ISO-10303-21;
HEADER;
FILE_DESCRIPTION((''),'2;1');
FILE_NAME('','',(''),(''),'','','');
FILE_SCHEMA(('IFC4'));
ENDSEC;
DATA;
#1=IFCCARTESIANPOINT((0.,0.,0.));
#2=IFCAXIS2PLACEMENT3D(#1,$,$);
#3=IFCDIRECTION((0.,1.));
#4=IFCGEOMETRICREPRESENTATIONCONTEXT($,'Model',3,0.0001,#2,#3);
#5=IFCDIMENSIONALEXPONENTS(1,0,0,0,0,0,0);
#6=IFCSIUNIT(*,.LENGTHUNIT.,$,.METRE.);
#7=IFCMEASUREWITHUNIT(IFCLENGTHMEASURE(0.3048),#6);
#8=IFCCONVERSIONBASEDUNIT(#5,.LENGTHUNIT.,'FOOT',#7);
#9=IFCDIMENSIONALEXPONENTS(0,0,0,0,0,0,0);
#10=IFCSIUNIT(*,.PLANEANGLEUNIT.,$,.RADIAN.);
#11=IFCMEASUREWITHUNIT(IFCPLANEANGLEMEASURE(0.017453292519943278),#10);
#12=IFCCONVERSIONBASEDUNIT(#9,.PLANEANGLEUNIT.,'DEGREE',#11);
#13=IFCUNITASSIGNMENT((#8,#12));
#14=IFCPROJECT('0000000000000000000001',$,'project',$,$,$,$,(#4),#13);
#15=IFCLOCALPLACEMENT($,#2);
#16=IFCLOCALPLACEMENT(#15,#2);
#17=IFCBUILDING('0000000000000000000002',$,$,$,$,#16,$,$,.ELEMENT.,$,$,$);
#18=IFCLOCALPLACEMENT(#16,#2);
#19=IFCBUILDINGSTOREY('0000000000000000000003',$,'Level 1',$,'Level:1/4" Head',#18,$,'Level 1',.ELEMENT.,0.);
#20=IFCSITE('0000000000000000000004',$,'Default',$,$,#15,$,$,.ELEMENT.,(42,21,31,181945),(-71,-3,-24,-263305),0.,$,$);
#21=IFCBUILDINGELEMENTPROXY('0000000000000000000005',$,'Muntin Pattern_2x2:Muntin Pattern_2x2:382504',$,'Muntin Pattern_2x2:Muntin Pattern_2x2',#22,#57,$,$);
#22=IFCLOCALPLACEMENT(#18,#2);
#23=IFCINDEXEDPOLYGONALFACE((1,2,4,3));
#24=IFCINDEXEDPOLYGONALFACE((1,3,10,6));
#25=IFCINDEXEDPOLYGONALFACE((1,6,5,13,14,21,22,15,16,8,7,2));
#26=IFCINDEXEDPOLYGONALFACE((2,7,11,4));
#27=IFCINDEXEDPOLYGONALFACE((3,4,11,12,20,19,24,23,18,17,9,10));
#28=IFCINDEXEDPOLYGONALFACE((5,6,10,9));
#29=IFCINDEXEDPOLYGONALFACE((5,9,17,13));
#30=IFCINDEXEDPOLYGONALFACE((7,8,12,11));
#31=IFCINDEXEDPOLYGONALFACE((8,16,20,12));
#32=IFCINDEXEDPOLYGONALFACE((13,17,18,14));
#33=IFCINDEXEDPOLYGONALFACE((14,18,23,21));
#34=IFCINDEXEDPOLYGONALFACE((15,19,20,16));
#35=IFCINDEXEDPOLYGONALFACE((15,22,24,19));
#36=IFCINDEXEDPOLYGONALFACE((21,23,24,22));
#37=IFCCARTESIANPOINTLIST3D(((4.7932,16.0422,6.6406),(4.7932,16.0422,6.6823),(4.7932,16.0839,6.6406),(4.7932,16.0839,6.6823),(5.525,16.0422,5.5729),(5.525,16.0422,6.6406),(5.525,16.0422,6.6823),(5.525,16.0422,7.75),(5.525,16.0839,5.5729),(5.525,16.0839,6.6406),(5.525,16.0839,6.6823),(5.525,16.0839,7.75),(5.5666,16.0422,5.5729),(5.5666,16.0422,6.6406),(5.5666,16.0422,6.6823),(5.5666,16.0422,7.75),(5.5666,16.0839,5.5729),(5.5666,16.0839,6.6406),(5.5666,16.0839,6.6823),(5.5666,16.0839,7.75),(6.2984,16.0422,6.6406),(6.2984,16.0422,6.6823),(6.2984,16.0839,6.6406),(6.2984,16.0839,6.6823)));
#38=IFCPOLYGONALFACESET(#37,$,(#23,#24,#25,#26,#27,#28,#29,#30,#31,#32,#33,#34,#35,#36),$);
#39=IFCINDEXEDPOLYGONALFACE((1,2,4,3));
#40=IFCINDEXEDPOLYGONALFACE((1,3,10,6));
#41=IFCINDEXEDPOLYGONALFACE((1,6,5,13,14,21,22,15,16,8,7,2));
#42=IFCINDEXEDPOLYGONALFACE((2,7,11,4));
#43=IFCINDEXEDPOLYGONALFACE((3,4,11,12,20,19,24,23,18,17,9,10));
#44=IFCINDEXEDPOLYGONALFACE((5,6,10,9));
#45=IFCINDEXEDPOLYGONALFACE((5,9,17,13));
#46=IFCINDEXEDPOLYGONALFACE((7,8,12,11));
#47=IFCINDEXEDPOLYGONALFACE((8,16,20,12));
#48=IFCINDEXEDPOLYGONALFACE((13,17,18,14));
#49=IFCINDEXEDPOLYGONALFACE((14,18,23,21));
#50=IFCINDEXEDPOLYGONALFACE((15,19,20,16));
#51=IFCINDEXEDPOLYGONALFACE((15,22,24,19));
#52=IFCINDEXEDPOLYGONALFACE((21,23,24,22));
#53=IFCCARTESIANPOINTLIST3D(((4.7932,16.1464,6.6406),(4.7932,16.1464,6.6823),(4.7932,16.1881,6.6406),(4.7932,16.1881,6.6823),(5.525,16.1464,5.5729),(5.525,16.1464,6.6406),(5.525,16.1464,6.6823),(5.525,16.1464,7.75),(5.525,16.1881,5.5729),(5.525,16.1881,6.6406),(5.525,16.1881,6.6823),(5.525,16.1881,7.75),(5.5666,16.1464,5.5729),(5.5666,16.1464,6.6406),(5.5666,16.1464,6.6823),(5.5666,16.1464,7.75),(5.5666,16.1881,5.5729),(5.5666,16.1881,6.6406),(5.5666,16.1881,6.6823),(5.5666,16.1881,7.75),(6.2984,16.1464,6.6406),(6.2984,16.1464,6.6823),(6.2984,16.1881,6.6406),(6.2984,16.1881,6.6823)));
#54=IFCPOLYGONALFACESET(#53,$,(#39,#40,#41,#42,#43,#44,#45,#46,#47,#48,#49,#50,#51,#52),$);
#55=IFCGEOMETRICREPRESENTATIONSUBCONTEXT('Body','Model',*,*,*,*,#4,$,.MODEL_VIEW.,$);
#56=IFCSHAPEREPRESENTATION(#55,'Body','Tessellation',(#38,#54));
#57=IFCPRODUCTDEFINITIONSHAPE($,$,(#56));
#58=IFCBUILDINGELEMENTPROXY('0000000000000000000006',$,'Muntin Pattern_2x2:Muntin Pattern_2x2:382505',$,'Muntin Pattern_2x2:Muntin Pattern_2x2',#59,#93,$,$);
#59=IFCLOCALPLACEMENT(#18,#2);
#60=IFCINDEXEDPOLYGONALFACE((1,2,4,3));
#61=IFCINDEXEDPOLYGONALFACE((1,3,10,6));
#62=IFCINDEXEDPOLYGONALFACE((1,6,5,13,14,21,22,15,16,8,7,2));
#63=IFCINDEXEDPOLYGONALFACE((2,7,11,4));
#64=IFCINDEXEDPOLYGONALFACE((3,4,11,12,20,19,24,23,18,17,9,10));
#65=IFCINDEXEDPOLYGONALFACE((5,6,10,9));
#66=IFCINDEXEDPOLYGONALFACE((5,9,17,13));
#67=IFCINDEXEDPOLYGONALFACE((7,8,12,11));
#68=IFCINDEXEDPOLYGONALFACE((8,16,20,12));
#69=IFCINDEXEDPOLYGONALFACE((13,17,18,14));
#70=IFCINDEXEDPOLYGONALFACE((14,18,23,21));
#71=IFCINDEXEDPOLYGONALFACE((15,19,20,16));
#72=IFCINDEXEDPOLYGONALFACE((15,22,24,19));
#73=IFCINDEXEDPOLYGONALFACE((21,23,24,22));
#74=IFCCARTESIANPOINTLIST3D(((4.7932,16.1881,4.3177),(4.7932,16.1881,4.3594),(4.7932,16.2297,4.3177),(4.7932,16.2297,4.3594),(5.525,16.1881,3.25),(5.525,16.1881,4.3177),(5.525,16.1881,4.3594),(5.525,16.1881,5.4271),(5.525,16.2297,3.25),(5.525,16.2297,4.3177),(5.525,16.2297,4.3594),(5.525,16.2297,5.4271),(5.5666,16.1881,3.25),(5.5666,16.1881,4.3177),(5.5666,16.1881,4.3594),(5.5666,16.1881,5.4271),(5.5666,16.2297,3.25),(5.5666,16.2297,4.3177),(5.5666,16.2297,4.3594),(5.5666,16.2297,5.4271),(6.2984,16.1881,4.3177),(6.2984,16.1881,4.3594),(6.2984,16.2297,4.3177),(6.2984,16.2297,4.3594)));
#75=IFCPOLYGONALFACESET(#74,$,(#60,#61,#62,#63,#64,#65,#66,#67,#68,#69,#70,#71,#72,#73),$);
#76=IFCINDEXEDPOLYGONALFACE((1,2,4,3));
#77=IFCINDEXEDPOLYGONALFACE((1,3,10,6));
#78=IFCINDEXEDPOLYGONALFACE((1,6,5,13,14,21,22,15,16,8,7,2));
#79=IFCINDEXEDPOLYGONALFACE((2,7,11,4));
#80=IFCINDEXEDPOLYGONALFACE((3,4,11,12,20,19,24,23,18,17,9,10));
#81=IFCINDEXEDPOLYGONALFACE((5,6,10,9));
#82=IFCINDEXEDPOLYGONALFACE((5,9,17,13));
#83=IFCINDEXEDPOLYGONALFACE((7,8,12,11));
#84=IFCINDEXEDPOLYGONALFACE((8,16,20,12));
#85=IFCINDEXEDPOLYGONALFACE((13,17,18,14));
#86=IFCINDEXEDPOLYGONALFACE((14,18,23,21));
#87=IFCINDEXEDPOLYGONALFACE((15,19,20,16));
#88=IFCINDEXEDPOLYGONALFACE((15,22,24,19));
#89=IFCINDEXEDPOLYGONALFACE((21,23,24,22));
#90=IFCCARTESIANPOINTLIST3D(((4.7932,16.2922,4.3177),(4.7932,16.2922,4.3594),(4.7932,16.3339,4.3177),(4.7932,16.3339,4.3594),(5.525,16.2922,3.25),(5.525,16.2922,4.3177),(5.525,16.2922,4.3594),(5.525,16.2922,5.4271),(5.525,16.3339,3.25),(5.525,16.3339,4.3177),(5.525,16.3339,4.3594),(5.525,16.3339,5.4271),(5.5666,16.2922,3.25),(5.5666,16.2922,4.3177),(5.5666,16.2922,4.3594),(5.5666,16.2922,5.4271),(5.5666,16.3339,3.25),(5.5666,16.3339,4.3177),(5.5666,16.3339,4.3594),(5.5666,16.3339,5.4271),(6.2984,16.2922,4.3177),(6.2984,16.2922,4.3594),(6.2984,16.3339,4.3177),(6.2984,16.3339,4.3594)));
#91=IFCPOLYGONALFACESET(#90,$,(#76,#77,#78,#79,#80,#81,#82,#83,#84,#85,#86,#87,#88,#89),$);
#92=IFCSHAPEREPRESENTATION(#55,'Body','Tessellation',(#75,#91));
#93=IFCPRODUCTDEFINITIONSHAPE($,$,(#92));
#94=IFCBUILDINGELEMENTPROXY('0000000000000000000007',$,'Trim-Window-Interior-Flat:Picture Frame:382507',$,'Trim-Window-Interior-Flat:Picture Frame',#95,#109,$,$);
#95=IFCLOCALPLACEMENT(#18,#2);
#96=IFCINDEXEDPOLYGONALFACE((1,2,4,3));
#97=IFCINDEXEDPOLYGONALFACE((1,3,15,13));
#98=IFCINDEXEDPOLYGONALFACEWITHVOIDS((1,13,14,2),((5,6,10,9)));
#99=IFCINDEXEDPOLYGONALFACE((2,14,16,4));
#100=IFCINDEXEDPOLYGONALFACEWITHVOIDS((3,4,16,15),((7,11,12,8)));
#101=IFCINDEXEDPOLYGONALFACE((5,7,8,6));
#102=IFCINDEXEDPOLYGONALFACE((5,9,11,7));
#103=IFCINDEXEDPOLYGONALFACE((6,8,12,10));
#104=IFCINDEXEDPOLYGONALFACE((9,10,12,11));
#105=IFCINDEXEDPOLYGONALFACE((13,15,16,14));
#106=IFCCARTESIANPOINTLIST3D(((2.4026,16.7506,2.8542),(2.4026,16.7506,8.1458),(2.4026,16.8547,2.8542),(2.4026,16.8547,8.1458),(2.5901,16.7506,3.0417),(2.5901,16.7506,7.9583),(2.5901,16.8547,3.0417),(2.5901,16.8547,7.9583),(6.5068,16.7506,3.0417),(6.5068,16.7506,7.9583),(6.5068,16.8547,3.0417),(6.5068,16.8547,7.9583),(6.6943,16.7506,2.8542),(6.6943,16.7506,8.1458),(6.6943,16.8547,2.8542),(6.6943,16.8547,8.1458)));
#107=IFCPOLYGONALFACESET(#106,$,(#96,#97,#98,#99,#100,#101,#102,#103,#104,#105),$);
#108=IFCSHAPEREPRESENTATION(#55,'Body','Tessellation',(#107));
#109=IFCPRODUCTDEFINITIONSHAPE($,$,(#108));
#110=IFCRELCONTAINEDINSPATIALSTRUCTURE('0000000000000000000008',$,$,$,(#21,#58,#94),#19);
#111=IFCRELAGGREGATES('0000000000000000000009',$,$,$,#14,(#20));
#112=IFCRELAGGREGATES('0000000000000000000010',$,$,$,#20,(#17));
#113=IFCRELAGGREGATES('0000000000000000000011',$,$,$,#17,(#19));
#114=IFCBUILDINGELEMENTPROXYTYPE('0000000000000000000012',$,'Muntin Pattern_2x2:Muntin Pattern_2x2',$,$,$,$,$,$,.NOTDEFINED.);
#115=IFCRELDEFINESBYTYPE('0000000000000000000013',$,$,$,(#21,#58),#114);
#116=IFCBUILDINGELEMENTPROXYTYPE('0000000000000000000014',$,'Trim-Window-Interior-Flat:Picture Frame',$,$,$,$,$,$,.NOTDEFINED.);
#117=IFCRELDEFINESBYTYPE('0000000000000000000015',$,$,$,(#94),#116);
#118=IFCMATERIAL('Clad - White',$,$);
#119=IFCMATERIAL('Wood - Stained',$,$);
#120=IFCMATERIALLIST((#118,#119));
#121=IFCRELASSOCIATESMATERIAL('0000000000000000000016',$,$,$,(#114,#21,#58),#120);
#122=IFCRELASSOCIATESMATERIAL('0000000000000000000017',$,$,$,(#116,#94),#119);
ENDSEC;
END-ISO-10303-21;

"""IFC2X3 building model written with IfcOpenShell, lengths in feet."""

from ifc_helpers import new_model, entity, si_unit, converted_unit, direction, frame, origin, place, context, subcontext, project, spatial, polyline, outline, extrude, source, transform, mapped, material, material_list, type_object, type_shapes, element, save


model = new_model("IFC2X3")

# Units and contexts
model_context = context("Model", 3, precision=0.0001, world=origin(), true_north=direction((0.0, 1.0)))
body_context = subcontext(model_context, "Body", "Model", "MODEL_VIEW")
ifc_project = project(units=[converted_unit("LENGTHUNIT", "FOOT", entity("IfcLengthMeasure", 0.3048), si_unit("LENGTHUNIT", "METRE"), dimensions=[1, 0, 0, 0, 0, 0, 0]), converted_unit("PLANEANGLEUNIT", "DEGREE", entity("IfcPlaneAngleMeasure", 0.017453292519943278), si_unit("PLANEANGLEUNIT", "RADIAN"), dimensions=[0, 0, 0, 0, 0, 0, 0])], contexts=[model_context])

# Site, building, storey
site_placement = place(None, origin())
site = spatial("IfcSite", under=ifc_project, at=site_placement, Name="Default", CompositionType="ELEMENT", RefLatitude=(42, 21, 31, 181945), RefLongitude=(-71, -3, -24, -263305), RefElevation=0.0)
building_placement = place(site_placement, origin())
building = spatial("IfcBuilding", under=site, at=building_placement, CompositionType="ELEMENT")
storey_placement = place(building_placement, origin())
storey = spatial("IfcBuildingStorey", under=building, at=storey_placement, Name="Level 1", ObjectType="Level:1/4\" Head", LongName="Level 1", CompositionType="ELEMENT", Elevation=0.0)

# Shared definitions
ifc_material_1 = material(Name="Wood - Stained")

# Building element proxies
ifc_material_2 = material(Name="Clad - White")
ifc_material_list_1 = material_list([ifc_material_2, ifc_material_1])
building_element_proxy_type_1 = type_object("IfcBuildingElementProxyType", Name="Muntin Pattern_2x2:Muntin Pattern_2x2", PredefinedType="NOTDEFINED", material=ifc_material_list_1)
shared_shape_1 = source(origin(), body_context, "Body", "SweptSolid", [
    extrude(outline(polyline([(0.0208, -0.0208), (1.0885, -0.0208), (1.0885, 0.0208), (0.0208, 0.0208), (0.0208, 0.7526), (-0.0208, 0.7526), (-0.0208, 0.0208), (-1.0885, 0.0208), (-1.0885, -0.0208), (-0.0208, -0.0208), (-0.0208, -0.7526), (0.0208, -0.7526), (0.0208, -0.0208)])), frame((0.0, -0.0729, 1.0885), z_axis=(0.0, 1.0, 0.0), x_axis=(0.0, 0.0, 1.0)), (0.0, 0.0, 1.0), 0.0417),
    extrude(outline(polyline([(0.0208, -0.0208), (1.0885, -0.0208), (1.0885, 0.0208), (0.0208, 0.0208), (0.0208, 0.7526), (-0.0208, 0.7526), (-0.0208, 0.0208), (-1.0885, 0.0208), (-1.0885, -0.0208), (-0.0208, -0.0208), (-0.0208, -0.7526), (0.0208, -0.7526), (0.0208, -0.0208)])), frame((0.0, 0.0313, 1.0885), z_axis=(0.0, 1.0, 0.0), x_axis=(0.0, 0.0, 1.0)), (0.0, 0.0, 1.0), 0.0417),
])
type_shapes(building_element_proxy_type_1, [shared_shape_1])
for number, where, name in (
    (1, (5.5458, 16.1152, 5.5729), "Muntin Pattern_2x2:Muntin Pattern_2x2:382504"),
    (2, (5.5458, 16.261, 3.25), "Muntin Pattern_2x2:Muntin Pattern_2x2:382505"),
):
    element("IfcBuildingElementProxy", number, at=place(storey_placement, frame(where)), inside=storey, type_object=building_element_proxy_type_1, material=ifc_material_list_1, Name=name, ObjectType="Muntin Pattern_2x2:Muntin Pattern_2x2", context=body_context, shape_type="MappedRepresentation", body=[
        mapped(shared_shape_1, transform((0.0, 0.0, 0.0), scale=1.0)),
    ])
building_element_proxy_type_2 = type_object("IfcBuildingElementProxyType", Name="Trim-Window-Interior-Flat:Picture Frame", PredefinedType="NOTDEFINED", material=ifc_material_1)
shared_shape_2 = source(origin(), body_context, "Body", "SweptSolid", [
    extrude(outline(polyline([(-2.1458, -2.6458), (2.1458, -2.6458), (2.1458, 2.6458), (-2.1458, 2.6458), (-2.1458, -2.6458)]), holes=[polyline([(-1.9583, -2.4583), (-1.9583, 2.4583), (1.9583, 2.4583), (1.9583, -2.4583), (-1.9583, -2.4583)])]), frame((0.0, -2.5, 0.0), z_axis=(0.0, 0.0, 1.0), x_axis=(-1.0, 0.0, 0.0)), (0.0, 0.0, 1.0), 0.1042),
])
type_shapes(building_element_proxy_type_2, [shared_shape_2])
proxy_1_placement = place(storey_placement, frame((4.5484, 16.7506, 8.0), z_axis=(0.0, 1.0, 0.0), x_axis=(-1.0, 0.0, 0.0)))
element("IfcBuildingElementProxy", 3, at=proxy_1_placement, inside=storey, type_object=building_element_proxy_type_2, material=ifc_material_1, Name="Trim-Window-Interior-Flat:Picture Frame:382507", ObjectType="Trim-Window-Interior-Flat:Picture Frame", context=body_context, shape_type="MappedRepresentation", body=[
    mapped(shared_shape_2, transform((0.0, 0.0, 0.0), scale=1.0)),
])

save(model, "model.ifc")
